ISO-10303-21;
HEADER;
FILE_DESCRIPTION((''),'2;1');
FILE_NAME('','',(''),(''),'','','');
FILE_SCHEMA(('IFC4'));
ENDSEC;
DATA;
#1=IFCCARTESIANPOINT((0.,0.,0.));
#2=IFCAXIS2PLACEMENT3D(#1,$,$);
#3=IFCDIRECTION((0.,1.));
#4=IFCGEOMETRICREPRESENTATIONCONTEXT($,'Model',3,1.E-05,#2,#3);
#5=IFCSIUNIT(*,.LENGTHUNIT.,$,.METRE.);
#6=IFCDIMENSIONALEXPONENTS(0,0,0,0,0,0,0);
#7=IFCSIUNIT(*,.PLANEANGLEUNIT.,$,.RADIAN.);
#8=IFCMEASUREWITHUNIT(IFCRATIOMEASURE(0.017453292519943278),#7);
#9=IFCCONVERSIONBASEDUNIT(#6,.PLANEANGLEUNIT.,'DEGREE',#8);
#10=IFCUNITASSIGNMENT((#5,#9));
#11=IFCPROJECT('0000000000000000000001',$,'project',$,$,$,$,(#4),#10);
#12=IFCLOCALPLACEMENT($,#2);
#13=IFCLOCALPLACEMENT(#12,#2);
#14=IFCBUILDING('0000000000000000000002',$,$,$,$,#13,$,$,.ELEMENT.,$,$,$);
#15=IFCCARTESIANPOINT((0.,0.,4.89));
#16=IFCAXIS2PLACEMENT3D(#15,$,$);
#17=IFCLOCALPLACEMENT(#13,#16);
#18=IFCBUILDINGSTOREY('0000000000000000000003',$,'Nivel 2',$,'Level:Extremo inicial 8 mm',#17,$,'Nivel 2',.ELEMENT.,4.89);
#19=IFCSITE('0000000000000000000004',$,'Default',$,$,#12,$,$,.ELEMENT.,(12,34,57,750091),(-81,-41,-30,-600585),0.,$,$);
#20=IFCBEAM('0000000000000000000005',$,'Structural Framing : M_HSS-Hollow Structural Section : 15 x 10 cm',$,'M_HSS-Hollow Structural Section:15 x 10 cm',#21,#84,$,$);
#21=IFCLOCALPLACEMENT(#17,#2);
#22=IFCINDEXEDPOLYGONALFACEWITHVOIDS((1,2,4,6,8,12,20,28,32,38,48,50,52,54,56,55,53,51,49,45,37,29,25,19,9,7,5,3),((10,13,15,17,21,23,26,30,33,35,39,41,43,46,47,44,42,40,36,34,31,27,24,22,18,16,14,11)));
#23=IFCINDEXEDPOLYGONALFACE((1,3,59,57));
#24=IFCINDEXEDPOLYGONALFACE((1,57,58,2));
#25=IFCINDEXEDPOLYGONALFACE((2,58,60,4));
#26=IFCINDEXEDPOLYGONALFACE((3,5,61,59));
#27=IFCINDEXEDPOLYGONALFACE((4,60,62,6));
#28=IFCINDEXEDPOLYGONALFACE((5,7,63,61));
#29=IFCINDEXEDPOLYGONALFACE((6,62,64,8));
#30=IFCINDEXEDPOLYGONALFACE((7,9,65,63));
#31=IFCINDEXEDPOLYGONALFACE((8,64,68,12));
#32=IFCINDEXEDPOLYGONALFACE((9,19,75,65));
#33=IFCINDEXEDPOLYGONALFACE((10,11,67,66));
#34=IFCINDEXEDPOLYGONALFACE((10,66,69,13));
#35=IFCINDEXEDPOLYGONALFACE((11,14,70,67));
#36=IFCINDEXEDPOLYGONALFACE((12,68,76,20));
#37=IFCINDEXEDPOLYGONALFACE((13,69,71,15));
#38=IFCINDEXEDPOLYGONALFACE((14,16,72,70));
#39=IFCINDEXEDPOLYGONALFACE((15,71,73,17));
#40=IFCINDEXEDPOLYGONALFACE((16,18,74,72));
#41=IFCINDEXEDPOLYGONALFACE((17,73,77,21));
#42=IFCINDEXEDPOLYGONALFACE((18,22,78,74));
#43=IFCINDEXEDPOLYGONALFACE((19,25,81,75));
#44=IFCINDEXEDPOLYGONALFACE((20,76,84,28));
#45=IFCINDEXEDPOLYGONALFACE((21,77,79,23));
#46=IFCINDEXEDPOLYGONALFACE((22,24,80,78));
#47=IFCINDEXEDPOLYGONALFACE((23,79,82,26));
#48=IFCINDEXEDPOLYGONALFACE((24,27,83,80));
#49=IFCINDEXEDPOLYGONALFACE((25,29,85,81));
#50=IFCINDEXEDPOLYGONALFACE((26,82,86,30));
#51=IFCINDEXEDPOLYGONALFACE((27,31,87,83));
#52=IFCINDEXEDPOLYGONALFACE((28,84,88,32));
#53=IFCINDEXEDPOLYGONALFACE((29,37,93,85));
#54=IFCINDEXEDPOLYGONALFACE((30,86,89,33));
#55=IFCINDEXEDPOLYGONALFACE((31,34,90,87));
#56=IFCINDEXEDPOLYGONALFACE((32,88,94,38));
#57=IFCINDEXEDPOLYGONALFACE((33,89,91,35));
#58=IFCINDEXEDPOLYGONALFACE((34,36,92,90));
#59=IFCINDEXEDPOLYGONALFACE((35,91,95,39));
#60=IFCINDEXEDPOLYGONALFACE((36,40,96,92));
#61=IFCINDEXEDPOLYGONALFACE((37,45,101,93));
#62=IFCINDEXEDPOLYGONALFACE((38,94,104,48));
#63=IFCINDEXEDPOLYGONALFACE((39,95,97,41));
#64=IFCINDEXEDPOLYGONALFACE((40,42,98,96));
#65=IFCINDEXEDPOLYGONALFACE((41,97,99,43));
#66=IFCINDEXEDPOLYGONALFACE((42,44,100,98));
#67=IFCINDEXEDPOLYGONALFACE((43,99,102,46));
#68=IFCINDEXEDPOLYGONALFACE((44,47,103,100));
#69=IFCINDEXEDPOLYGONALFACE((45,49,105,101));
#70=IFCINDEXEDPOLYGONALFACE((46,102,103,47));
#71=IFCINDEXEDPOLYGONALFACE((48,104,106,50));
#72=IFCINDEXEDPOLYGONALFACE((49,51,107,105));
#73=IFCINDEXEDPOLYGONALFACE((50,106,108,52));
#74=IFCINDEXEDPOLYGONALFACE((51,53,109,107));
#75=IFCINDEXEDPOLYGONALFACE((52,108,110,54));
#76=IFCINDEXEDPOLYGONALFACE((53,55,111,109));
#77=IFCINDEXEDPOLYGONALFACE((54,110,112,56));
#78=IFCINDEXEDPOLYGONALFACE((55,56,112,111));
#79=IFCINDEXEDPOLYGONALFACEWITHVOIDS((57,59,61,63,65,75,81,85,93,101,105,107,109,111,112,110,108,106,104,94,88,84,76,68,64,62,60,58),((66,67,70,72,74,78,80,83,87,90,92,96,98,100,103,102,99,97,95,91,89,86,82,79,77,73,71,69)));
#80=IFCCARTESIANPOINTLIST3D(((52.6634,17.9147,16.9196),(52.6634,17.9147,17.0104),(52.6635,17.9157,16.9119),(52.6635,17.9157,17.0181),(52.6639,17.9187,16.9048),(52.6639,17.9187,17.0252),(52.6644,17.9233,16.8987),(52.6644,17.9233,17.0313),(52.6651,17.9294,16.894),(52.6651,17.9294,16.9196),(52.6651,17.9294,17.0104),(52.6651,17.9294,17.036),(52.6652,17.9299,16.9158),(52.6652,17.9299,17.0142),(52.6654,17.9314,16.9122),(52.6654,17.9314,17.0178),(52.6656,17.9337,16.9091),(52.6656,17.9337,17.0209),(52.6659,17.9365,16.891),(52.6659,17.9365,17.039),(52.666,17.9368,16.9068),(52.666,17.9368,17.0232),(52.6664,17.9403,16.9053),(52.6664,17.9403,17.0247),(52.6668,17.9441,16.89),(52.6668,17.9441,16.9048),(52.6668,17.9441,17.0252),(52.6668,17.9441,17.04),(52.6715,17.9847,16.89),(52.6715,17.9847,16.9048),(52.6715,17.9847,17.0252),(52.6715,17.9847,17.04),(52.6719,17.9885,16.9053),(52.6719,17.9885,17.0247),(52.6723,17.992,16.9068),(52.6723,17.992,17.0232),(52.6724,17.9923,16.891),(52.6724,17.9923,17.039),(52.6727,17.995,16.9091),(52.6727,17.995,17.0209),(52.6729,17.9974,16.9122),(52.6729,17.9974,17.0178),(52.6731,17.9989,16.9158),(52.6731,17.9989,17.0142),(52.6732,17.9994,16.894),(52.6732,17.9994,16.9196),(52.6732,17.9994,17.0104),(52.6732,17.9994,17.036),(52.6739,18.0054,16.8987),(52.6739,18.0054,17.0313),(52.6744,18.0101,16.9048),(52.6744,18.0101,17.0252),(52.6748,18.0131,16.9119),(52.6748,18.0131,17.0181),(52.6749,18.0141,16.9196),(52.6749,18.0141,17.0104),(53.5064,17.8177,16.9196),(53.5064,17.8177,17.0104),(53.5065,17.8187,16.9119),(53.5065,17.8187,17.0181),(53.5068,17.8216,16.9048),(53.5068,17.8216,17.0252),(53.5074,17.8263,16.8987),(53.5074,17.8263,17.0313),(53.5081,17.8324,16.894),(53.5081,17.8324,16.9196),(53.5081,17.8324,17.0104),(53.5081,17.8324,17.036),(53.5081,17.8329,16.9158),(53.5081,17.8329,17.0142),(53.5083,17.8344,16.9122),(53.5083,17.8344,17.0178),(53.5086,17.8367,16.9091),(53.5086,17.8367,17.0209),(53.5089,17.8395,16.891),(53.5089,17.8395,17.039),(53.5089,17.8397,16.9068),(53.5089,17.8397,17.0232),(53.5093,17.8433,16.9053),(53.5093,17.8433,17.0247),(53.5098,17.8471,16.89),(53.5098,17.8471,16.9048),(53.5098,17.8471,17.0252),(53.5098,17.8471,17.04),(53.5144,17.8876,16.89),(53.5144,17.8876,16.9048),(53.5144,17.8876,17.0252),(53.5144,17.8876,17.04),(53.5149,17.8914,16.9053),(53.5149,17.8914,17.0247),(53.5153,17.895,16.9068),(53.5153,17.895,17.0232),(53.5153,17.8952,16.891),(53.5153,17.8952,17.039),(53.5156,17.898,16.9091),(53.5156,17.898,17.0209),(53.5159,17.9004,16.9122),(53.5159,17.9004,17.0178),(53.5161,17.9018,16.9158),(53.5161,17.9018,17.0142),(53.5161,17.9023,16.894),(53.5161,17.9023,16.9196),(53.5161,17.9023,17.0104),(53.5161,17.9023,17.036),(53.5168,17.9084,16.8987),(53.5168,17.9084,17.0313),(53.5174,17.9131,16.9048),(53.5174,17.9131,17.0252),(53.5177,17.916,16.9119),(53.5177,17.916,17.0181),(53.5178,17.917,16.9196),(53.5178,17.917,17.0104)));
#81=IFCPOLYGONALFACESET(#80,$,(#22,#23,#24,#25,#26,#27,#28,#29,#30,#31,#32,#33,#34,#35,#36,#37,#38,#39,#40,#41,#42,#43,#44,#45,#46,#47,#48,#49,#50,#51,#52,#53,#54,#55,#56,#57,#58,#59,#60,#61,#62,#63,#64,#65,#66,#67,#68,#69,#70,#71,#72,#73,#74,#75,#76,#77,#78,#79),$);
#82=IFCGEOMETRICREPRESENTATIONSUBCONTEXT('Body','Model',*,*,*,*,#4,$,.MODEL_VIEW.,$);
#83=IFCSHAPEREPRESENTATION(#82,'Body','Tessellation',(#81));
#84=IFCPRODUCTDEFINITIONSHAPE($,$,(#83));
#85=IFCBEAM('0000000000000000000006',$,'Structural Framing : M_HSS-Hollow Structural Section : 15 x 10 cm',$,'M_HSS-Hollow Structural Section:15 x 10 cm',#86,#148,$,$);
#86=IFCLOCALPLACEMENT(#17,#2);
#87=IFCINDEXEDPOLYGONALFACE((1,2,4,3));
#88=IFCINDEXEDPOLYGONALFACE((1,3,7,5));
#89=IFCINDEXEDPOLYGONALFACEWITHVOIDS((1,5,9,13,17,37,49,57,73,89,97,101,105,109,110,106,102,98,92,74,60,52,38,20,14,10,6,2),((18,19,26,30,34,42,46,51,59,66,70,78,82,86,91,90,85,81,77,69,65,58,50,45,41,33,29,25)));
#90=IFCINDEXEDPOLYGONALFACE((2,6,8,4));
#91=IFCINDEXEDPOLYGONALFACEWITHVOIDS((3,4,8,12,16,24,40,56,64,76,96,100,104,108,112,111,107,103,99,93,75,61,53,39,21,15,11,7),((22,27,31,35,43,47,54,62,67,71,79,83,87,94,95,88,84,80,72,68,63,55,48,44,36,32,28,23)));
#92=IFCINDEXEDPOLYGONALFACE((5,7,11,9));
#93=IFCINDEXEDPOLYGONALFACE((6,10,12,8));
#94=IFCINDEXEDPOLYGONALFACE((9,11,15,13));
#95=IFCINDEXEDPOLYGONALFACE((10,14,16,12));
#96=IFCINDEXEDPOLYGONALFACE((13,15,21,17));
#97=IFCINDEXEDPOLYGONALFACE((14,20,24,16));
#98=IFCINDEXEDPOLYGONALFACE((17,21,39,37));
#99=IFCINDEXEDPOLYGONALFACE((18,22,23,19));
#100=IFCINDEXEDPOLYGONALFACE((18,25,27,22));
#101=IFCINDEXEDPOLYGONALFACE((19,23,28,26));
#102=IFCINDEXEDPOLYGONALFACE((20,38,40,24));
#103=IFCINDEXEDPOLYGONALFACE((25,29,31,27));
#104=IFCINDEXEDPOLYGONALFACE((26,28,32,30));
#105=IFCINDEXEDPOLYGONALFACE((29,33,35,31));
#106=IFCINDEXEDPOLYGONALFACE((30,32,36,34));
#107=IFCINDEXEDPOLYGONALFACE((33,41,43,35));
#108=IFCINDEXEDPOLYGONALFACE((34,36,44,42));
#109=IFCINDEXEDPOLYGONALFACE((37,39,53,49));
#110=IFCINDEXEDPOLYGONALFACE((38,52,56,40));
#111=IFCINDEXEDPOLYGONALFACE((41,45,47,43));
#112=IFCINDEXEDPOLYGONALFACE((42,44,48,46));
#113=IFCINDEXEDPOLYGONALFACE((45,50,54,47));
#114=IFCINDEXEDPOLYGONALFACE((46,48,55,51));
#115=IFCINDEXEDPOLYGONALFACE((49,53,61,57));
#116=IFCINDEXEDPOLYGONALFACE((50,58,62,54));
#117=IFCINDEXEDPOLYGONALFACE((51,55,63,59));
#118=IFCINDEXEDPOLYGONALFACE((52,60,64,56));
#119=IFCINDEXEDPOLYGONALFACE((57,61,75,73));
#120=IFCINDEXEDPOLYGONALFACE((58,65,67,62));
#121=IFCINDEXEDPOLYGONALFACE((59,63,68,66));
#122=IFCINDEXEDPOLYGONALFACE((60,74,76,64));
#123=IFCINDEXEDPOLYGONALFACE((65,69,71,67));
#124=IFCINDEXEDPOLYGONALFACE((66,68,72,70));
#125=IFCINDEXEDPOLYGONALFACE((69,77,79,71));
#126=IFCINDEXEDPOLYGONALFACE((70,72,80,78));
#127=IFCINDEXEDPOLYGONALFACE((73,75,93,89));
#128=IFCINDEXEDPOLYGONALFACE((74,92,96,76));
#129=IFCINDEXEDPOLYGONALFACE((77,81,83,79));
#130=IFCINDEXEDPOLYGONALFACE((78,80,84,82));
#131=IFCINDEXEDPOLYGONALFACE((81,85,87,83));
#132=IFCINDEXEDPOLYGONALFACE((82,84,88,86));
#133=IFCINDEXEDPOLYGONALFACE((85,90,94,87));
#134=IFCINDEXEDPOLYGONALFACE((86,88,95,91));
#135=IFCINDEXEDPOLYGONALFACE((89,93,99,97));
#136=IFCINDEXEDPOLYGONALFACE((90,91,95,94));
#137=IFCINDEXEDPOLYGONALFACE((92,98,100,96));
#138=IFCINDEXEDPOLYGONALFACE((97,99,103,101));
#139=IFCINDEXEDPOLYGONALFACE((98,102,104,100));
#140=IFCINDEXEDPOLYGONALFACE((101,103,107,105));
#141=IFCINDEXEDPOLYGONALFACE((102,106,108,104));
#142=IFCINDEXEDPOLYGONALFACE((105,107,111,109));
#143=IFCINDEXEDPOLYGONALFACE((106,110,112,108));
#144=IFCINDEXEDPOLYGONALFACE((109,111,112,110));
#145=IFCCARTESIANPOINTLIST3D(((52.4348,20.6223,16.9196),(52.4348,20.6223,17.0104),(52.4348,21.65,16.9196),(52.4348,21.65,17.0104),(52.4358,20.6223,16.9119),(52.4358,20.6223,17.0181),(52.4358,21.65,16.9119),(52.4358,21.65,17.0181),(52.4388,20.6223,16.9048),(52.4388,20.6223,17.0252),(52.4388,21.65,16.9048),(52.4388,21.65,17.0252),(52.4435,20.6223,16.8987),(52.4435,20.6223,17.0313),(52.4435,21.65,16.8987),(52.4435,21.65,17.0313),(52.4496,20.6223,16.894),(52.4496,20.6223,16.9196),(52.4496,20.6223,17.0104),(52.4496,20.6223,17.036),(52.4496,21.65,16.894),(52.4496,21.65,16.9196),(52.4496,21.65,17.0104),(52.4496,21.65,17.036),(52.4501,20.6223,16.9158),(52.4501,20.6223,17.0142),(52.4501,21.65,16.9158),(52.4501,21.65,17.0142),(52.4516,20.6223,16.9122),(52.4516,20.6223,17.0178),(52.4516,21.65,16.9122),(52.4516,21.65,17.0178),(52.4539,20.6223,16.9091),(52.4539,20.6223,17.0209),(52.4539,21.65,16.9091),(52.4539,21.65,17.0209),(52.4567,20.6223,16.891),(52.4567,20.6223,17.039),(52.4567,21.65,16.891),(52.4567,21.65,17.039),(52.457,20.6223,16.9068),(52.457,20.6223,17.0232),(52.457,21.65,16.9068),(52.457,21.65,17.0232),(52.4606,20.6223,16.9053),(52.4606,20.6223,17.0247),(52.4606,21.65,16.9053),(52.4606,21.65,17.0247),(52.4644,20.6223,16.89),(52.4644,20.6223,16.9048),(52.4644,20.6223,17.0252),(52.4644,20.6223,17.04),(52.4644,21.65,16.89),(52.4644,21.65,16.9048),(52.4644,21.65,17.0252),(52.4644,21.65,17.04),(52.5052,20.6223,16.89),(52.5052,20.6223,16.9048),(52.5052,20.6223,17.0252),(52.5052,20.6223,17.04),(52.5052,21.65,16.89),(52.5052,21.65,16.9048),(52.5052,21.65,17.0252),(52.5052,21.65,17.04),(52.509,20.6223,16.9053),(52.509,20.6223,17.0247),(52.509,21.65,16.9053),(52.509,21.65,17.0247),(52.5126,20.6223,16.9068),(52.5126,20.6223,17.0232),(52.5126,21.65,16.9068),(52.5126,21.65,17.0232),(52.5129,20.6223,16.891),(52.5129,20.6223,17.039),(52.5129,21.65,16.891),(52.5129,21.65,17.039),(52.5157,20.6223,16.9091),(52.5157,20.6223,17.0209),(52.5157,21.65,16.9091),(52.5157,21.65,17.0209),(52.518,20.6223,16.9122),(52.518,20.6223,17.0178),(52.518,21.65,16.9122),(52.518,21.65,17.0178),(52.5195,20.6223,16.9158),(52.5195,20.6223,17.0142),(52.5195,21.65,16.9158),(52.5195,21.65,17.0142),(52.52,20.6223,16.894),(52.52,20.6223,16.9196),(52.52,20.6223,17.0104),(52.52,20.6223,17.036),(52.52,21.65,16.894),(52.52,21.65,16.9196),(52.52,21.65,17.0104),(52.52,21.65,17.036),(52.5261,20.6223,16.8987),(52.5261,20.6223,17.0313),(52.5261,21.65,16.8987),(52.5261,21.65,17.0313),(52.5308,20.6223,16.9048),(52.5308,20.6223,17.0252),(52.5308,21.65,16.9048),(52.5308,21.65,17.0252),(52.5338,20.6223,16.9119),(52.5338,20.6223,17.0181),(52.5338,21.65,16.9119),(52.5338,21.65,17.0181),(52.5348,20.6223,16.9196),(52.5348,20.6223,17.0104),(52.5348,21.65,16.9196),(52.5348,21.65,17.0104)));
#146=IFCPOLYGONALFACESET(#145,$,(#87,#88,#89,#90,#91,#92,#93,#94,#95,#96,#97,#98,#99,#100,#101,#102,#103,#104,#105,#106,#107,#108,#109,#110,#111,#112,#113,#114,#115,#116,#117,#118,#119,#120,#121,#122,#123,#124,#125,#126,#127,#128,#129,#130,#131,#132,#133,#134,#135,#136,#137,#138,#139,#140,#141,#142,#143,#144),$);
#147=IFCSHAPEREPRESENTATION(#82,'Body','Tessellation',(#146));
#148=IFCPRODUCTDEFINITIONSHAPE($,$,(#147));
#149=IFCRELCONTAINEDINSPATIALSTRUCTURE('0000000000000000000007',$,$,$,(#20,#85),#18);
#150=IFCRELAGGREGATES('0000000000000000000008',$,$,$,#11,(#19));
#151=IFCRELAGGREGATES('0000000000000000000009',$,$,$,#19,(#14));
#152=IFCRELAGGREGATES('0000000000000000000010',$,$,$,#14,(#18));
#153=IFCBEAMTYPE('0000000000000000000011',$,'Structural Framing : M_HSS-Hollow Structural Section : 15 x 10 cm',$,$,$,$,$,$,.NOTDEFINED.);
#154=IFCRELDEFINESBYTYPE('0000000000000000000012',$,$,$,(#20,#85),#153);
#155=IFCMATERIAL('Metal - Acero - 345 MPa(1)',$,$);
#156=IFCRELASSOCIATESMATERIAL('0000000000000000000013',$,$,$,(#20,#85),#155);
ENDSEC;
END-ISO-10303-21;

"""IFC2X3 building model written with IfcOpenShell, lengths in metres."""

from ifc_helpers import new_model, entity, si_unit, converted_unit, direction, frame, frame_2d, origin, place, context, subcontext, project, spatial, polyline, circle_curve, parameter, trimmed, segment, composite_curve, outline, extrude, material, type_object, element, save


model = new_model("IFC2X3")

# Units and contexts
model_context = context("Model", 3, precision=1e-05, world=origin(), true_north=direction((0.0, 1.0)))
body_context = subcontext(model_context, "Body", "Model", "MODEL_VIEW")
ifc_project = project(units=[si_unit("LENGTHUNIT", "METRE"), converted_unit("PLANEANGLEUNIT", "DEGREE", entity("IfcRatioMeasure", 0.017453292519943278), si_unit("PLANEANGLEUNIT", "RADIAN"), dimensions=[0, 0, 0, 0, 0, 0, 0])], contexts=[model_context])

# Site, building, storey
site_placement = place(None, origin())
site = spatial("IfcSite", under=ifc_project, at=site_placement, Name="Default", CompositionType="ELEMENT", RefLatitude=(12, 34, 57, 750091), RefLongitude=(-81, -41, -30, -600585), RefElevation=0.0)
building_placement = place(site_placement, origin())
building = spatial("IfcBuilding", under=site, at=building_placement, CompositionType="ELEMENT")
storey_placement = place(building_placement, frame((0.0, 0.0, 4.89)))
storey = spatial("IfcBuildingStorey", under=building, at=storey_placement, Name="Nivel 2", ObjectType="Level:Extremo inicial 8 mm", LongName="Nivel 2", CompositionType="ELEMENT", Elevation=4.89)

# Shared definitions
ifc_material_1 = material(Name="Metal - Acero - 345 MPa(1)")

# Beams
beam_type_1 = type_object("IfcBeamType", Name="Structural Framing : M_HSS-Hollow Structural Section : 15 x 10 cm", PredefinedType="NOTDEFINED")
beam_1_placement = place(storey_placement, frame((53.8598, 17.8273, 17.04), z_axis=(0.0, 0.0, 1.0), x_axis=(-0.993441, 0.114344, 0.0)))
element("IfcBeam", 1, at=beam_1_placement, inside=storey, type_object=beam_type_1, material=ifc_material_1, Name="Structural Framing : M_HSS-Hollow Structural Section : 15 x 10 cm", ObjectType="M_HSS-Hollow Structural Section:15 x 10 cm", context=body_context, shape_type="SweptSolid", body=[
    extrude(outline(composite_curve([segment(trimmed(circle_curve(frame_2d((-0.0204, -0.0454), x_axis=(1.0, 0.0)), 0.0296), [parameter(180.0)], [parameter(270.0)], True, "PARAMETER"), True, "CONTINUOUS"), segment(polyline([(-0.0204, -0.075), (0.0204, -0.075)]), True, "CONTINUOUS"), segment(trimmed(circle_curve(frame_2d((0.0204, -0.0454), x_axis=(1.0, 0.0)), 0.0296), [parameter(270.0)], [parameter(0.0)], True, "PARAMETER"), True, "CONTINUOUS"), segment(polyline([(0.05, -0.0454), (0.05, 0.0454)]), True, "CONTINUOUS"), segment(trimmed(circle_curve(frame_2d((0.0204, 0.0454), x_axis=(1.0, 0.0)), 0.0296), [parameter(360.0)], [parameter(90.0)], True, "PARAMETER"), True, "CONTINUOUS"), segment(polyline([(0.0204, 0.075), (-0.0204, 0.075)]), True, "CONTINUOUS"), segment(trimmed(circle_curve(frame_2d((-0.0204, 0.0454), x_axis=(1.0, 0.0)), 0.0296), [parameter(90.0)], [parameter(180.0)], True, "PARAMETER"), True, "CONTINUOUS"), segment(polyline([(-0.05, 0.0454), (-0.05, -0.0454)]), True, "CONTINUOUS")], self_intersect=False), holes=[composite_curve([segment(polyline([(0.0204, -0.0602), (-0.0204, -0.0602)]), True, "CONTINUOUS"), segment(trimmed(circle_curve(frame_2d((-0.0204, -0.0454), x_axis=(1.0, 0.0)), 0.0148), [parameter(180.0)], [parameter(270.0)], True, "PARAMETER"), False, "CONTINUOUS"), segment(polyline([(-0.0352, -0.0454), (-0.0352, 0.0454)]), True, "CONTINUOUS"), segment(trimmed(circle_curve(frame_2d((-0.0204, 0.0454), x_axis=(1.0, 0.0)), 0.0148), [parameter(90.0)], [parameter(180.0)], True, "PARAMETER"), False, "CONTINUOUS"), segment(polyline([(-0.0204, 0.0602), (0.0204, 0.0602)]), True, "CONTINUOUS"), segment(trimmed(circle_curve(frame_2d((0.0204, 0.0454), x_axis=(1.0, 0.0)), 0.0148), [parameter(0.0)], [parameter(90.0)], True, "PARAMETER"), False, "CONTINUOUS"), segment(polyline([(0.0352, 0.0454), (0.0352, -0.0454)]), True, "CONTINUOUS"), segment(trimmed(circle_curve(frame_2d((0.0204, -0.0454), x_axis=(1.0, 0.0)), 0.0148), [parameter(270.0)], [parameter(0.0)], True, "PARAMETER"), False, "CONTINUOUS")], self_intersect=False)]), frame((0.35, 0.0, -0.075), z_axis=(1.0, 0.0, 0.0), x_axis=(0.0, -1.0, 0.0)), (0.0, 0.0, 1.0), 0.8485),
])
beam_2_placement = place(storey_placement, frame((52.4848, 21.95, 17.04), z_axis=(0.0, 0.0, 1.0), x_axis=(0.0, -1.0, 0.0)))
element("IfcBeam", 2, at=beam_2_placement, inside=storey, type_object=beam_type_1, material=ifc_material_1, Name="Structural Framing : M_HSS-Hollow Structural Section : 15 x 10 cm", ObjectType="M_HSS-Hollow Structural Section:15 x 10 cm", context=body_context, shape_type="SweptSolid", body=[
    extrude(outline(composite_curve([segment(trimmed(circle_curve(frame_2d((-0.0204, -0.0454), x_axis=(1.0, 0.0)), 0.0296), [parameter(180.0)], [parameter(270.0)], True, "PARAMETER"), True, "CONTINUOUS"), segment(polyline([(-0.0204, -0.075), (0.0204, -0.075)]), True, "CONTINUOUS"), segment(trimmed(circle_curve(frame_2d((0.0204, -0.0454), x_axis=(1.0, 0.0)), 0.0296), [parameter(270.0)], [parameter(0.0)], True, "PARAMETER"), True, "CONTINUOUS"), segment(polyline([(0.05, -0.0454), (0.05, 0.0454)]), True, "CONTINUOUS"), segment(trimmed(circle_curve(frame_2d((0.0204, 0.0454), x_axis=(1.0, 0.0)), 0.0296), [parameter(360.0)], [parameter(90.0)], True, "PARAMETER"), True, "CONTINUOUS"), segment(polyline([(0.0204, 0.075), (-0.0204, 0.075)]), True, "CONTINUOUS"), segment(trimmed(circle_curve(frame_2d((-0.0204, 0.0454), x_axis=(1.0, 0.0)), 0.0296), [parameter(90.0)], [parameter(180.0)], True, "PARAMETER"), True, "CONTINUOUS"), segment(polyline([(-0.05, 0.0454), (-0.05, -0.0454)]), True, "CONTINUOUS")], self_intersect=False), holes=[composite_curve([segment(polyline([(0.0204, -0.0602), (-0.0204, -0.0602)]), True, "CONTINUOUS"), segment(trimmed(circle_curve(frame_2d((-0.0204, -0.0454), x_axis=(1.0, 0.0)), 0.0148), [parameter(180.0)], [parameter(270.0)], True, "PARAMETER"), False, "CONTINUOUS"), segment(polyline([(-0.0352, -0.0454), (-0.0352, 0.0454)]), True, "CONTINUOUS"), segment(trimmed(circle_curve(frame_2d((-0.0204, 0.0454), x_axis=(1.0, 0.0)), 0.0148), [parameter(90.0)], [parameter(180.0)], True, "PARAMETER"), False, "CONTINUOUS"), segment(polyline([(-0.0204, 0.0602), (0.0204, 0.0602)]), True, "CONTINUOUS"), segment(trimmed(circle_curve(frame_2d((0.0204, 0.0454), x_axis=(1.0, 0.0)), 0.0148), [parameter(0.0)], [parameter(90.0)], True, "PARAMETER"), False, "CONTINUOUS"), segment(polyline([(0.0352, 0.0454), (0.0352, -0.0454)]), True, "CONTINUOUS"), segment(trimmed(circle_curve(frame_2d((0.0204, -0.0454), x_axis=(1.0, 0.0)), 0.0148), [parameter(270.0)], [parameter(0.0)], True, "PARAMETER"), False, "CONTINUOUS")], self_intersect=False)]), frame((0.3, 0.0, -0.075), z_axis=(1.0, 0.0, 0.0), x_axis=(0.0, -1.0, 0.0)), (0.0, 0.0, 1.0), 1.0277),
])

save(model, "model.ifc")
